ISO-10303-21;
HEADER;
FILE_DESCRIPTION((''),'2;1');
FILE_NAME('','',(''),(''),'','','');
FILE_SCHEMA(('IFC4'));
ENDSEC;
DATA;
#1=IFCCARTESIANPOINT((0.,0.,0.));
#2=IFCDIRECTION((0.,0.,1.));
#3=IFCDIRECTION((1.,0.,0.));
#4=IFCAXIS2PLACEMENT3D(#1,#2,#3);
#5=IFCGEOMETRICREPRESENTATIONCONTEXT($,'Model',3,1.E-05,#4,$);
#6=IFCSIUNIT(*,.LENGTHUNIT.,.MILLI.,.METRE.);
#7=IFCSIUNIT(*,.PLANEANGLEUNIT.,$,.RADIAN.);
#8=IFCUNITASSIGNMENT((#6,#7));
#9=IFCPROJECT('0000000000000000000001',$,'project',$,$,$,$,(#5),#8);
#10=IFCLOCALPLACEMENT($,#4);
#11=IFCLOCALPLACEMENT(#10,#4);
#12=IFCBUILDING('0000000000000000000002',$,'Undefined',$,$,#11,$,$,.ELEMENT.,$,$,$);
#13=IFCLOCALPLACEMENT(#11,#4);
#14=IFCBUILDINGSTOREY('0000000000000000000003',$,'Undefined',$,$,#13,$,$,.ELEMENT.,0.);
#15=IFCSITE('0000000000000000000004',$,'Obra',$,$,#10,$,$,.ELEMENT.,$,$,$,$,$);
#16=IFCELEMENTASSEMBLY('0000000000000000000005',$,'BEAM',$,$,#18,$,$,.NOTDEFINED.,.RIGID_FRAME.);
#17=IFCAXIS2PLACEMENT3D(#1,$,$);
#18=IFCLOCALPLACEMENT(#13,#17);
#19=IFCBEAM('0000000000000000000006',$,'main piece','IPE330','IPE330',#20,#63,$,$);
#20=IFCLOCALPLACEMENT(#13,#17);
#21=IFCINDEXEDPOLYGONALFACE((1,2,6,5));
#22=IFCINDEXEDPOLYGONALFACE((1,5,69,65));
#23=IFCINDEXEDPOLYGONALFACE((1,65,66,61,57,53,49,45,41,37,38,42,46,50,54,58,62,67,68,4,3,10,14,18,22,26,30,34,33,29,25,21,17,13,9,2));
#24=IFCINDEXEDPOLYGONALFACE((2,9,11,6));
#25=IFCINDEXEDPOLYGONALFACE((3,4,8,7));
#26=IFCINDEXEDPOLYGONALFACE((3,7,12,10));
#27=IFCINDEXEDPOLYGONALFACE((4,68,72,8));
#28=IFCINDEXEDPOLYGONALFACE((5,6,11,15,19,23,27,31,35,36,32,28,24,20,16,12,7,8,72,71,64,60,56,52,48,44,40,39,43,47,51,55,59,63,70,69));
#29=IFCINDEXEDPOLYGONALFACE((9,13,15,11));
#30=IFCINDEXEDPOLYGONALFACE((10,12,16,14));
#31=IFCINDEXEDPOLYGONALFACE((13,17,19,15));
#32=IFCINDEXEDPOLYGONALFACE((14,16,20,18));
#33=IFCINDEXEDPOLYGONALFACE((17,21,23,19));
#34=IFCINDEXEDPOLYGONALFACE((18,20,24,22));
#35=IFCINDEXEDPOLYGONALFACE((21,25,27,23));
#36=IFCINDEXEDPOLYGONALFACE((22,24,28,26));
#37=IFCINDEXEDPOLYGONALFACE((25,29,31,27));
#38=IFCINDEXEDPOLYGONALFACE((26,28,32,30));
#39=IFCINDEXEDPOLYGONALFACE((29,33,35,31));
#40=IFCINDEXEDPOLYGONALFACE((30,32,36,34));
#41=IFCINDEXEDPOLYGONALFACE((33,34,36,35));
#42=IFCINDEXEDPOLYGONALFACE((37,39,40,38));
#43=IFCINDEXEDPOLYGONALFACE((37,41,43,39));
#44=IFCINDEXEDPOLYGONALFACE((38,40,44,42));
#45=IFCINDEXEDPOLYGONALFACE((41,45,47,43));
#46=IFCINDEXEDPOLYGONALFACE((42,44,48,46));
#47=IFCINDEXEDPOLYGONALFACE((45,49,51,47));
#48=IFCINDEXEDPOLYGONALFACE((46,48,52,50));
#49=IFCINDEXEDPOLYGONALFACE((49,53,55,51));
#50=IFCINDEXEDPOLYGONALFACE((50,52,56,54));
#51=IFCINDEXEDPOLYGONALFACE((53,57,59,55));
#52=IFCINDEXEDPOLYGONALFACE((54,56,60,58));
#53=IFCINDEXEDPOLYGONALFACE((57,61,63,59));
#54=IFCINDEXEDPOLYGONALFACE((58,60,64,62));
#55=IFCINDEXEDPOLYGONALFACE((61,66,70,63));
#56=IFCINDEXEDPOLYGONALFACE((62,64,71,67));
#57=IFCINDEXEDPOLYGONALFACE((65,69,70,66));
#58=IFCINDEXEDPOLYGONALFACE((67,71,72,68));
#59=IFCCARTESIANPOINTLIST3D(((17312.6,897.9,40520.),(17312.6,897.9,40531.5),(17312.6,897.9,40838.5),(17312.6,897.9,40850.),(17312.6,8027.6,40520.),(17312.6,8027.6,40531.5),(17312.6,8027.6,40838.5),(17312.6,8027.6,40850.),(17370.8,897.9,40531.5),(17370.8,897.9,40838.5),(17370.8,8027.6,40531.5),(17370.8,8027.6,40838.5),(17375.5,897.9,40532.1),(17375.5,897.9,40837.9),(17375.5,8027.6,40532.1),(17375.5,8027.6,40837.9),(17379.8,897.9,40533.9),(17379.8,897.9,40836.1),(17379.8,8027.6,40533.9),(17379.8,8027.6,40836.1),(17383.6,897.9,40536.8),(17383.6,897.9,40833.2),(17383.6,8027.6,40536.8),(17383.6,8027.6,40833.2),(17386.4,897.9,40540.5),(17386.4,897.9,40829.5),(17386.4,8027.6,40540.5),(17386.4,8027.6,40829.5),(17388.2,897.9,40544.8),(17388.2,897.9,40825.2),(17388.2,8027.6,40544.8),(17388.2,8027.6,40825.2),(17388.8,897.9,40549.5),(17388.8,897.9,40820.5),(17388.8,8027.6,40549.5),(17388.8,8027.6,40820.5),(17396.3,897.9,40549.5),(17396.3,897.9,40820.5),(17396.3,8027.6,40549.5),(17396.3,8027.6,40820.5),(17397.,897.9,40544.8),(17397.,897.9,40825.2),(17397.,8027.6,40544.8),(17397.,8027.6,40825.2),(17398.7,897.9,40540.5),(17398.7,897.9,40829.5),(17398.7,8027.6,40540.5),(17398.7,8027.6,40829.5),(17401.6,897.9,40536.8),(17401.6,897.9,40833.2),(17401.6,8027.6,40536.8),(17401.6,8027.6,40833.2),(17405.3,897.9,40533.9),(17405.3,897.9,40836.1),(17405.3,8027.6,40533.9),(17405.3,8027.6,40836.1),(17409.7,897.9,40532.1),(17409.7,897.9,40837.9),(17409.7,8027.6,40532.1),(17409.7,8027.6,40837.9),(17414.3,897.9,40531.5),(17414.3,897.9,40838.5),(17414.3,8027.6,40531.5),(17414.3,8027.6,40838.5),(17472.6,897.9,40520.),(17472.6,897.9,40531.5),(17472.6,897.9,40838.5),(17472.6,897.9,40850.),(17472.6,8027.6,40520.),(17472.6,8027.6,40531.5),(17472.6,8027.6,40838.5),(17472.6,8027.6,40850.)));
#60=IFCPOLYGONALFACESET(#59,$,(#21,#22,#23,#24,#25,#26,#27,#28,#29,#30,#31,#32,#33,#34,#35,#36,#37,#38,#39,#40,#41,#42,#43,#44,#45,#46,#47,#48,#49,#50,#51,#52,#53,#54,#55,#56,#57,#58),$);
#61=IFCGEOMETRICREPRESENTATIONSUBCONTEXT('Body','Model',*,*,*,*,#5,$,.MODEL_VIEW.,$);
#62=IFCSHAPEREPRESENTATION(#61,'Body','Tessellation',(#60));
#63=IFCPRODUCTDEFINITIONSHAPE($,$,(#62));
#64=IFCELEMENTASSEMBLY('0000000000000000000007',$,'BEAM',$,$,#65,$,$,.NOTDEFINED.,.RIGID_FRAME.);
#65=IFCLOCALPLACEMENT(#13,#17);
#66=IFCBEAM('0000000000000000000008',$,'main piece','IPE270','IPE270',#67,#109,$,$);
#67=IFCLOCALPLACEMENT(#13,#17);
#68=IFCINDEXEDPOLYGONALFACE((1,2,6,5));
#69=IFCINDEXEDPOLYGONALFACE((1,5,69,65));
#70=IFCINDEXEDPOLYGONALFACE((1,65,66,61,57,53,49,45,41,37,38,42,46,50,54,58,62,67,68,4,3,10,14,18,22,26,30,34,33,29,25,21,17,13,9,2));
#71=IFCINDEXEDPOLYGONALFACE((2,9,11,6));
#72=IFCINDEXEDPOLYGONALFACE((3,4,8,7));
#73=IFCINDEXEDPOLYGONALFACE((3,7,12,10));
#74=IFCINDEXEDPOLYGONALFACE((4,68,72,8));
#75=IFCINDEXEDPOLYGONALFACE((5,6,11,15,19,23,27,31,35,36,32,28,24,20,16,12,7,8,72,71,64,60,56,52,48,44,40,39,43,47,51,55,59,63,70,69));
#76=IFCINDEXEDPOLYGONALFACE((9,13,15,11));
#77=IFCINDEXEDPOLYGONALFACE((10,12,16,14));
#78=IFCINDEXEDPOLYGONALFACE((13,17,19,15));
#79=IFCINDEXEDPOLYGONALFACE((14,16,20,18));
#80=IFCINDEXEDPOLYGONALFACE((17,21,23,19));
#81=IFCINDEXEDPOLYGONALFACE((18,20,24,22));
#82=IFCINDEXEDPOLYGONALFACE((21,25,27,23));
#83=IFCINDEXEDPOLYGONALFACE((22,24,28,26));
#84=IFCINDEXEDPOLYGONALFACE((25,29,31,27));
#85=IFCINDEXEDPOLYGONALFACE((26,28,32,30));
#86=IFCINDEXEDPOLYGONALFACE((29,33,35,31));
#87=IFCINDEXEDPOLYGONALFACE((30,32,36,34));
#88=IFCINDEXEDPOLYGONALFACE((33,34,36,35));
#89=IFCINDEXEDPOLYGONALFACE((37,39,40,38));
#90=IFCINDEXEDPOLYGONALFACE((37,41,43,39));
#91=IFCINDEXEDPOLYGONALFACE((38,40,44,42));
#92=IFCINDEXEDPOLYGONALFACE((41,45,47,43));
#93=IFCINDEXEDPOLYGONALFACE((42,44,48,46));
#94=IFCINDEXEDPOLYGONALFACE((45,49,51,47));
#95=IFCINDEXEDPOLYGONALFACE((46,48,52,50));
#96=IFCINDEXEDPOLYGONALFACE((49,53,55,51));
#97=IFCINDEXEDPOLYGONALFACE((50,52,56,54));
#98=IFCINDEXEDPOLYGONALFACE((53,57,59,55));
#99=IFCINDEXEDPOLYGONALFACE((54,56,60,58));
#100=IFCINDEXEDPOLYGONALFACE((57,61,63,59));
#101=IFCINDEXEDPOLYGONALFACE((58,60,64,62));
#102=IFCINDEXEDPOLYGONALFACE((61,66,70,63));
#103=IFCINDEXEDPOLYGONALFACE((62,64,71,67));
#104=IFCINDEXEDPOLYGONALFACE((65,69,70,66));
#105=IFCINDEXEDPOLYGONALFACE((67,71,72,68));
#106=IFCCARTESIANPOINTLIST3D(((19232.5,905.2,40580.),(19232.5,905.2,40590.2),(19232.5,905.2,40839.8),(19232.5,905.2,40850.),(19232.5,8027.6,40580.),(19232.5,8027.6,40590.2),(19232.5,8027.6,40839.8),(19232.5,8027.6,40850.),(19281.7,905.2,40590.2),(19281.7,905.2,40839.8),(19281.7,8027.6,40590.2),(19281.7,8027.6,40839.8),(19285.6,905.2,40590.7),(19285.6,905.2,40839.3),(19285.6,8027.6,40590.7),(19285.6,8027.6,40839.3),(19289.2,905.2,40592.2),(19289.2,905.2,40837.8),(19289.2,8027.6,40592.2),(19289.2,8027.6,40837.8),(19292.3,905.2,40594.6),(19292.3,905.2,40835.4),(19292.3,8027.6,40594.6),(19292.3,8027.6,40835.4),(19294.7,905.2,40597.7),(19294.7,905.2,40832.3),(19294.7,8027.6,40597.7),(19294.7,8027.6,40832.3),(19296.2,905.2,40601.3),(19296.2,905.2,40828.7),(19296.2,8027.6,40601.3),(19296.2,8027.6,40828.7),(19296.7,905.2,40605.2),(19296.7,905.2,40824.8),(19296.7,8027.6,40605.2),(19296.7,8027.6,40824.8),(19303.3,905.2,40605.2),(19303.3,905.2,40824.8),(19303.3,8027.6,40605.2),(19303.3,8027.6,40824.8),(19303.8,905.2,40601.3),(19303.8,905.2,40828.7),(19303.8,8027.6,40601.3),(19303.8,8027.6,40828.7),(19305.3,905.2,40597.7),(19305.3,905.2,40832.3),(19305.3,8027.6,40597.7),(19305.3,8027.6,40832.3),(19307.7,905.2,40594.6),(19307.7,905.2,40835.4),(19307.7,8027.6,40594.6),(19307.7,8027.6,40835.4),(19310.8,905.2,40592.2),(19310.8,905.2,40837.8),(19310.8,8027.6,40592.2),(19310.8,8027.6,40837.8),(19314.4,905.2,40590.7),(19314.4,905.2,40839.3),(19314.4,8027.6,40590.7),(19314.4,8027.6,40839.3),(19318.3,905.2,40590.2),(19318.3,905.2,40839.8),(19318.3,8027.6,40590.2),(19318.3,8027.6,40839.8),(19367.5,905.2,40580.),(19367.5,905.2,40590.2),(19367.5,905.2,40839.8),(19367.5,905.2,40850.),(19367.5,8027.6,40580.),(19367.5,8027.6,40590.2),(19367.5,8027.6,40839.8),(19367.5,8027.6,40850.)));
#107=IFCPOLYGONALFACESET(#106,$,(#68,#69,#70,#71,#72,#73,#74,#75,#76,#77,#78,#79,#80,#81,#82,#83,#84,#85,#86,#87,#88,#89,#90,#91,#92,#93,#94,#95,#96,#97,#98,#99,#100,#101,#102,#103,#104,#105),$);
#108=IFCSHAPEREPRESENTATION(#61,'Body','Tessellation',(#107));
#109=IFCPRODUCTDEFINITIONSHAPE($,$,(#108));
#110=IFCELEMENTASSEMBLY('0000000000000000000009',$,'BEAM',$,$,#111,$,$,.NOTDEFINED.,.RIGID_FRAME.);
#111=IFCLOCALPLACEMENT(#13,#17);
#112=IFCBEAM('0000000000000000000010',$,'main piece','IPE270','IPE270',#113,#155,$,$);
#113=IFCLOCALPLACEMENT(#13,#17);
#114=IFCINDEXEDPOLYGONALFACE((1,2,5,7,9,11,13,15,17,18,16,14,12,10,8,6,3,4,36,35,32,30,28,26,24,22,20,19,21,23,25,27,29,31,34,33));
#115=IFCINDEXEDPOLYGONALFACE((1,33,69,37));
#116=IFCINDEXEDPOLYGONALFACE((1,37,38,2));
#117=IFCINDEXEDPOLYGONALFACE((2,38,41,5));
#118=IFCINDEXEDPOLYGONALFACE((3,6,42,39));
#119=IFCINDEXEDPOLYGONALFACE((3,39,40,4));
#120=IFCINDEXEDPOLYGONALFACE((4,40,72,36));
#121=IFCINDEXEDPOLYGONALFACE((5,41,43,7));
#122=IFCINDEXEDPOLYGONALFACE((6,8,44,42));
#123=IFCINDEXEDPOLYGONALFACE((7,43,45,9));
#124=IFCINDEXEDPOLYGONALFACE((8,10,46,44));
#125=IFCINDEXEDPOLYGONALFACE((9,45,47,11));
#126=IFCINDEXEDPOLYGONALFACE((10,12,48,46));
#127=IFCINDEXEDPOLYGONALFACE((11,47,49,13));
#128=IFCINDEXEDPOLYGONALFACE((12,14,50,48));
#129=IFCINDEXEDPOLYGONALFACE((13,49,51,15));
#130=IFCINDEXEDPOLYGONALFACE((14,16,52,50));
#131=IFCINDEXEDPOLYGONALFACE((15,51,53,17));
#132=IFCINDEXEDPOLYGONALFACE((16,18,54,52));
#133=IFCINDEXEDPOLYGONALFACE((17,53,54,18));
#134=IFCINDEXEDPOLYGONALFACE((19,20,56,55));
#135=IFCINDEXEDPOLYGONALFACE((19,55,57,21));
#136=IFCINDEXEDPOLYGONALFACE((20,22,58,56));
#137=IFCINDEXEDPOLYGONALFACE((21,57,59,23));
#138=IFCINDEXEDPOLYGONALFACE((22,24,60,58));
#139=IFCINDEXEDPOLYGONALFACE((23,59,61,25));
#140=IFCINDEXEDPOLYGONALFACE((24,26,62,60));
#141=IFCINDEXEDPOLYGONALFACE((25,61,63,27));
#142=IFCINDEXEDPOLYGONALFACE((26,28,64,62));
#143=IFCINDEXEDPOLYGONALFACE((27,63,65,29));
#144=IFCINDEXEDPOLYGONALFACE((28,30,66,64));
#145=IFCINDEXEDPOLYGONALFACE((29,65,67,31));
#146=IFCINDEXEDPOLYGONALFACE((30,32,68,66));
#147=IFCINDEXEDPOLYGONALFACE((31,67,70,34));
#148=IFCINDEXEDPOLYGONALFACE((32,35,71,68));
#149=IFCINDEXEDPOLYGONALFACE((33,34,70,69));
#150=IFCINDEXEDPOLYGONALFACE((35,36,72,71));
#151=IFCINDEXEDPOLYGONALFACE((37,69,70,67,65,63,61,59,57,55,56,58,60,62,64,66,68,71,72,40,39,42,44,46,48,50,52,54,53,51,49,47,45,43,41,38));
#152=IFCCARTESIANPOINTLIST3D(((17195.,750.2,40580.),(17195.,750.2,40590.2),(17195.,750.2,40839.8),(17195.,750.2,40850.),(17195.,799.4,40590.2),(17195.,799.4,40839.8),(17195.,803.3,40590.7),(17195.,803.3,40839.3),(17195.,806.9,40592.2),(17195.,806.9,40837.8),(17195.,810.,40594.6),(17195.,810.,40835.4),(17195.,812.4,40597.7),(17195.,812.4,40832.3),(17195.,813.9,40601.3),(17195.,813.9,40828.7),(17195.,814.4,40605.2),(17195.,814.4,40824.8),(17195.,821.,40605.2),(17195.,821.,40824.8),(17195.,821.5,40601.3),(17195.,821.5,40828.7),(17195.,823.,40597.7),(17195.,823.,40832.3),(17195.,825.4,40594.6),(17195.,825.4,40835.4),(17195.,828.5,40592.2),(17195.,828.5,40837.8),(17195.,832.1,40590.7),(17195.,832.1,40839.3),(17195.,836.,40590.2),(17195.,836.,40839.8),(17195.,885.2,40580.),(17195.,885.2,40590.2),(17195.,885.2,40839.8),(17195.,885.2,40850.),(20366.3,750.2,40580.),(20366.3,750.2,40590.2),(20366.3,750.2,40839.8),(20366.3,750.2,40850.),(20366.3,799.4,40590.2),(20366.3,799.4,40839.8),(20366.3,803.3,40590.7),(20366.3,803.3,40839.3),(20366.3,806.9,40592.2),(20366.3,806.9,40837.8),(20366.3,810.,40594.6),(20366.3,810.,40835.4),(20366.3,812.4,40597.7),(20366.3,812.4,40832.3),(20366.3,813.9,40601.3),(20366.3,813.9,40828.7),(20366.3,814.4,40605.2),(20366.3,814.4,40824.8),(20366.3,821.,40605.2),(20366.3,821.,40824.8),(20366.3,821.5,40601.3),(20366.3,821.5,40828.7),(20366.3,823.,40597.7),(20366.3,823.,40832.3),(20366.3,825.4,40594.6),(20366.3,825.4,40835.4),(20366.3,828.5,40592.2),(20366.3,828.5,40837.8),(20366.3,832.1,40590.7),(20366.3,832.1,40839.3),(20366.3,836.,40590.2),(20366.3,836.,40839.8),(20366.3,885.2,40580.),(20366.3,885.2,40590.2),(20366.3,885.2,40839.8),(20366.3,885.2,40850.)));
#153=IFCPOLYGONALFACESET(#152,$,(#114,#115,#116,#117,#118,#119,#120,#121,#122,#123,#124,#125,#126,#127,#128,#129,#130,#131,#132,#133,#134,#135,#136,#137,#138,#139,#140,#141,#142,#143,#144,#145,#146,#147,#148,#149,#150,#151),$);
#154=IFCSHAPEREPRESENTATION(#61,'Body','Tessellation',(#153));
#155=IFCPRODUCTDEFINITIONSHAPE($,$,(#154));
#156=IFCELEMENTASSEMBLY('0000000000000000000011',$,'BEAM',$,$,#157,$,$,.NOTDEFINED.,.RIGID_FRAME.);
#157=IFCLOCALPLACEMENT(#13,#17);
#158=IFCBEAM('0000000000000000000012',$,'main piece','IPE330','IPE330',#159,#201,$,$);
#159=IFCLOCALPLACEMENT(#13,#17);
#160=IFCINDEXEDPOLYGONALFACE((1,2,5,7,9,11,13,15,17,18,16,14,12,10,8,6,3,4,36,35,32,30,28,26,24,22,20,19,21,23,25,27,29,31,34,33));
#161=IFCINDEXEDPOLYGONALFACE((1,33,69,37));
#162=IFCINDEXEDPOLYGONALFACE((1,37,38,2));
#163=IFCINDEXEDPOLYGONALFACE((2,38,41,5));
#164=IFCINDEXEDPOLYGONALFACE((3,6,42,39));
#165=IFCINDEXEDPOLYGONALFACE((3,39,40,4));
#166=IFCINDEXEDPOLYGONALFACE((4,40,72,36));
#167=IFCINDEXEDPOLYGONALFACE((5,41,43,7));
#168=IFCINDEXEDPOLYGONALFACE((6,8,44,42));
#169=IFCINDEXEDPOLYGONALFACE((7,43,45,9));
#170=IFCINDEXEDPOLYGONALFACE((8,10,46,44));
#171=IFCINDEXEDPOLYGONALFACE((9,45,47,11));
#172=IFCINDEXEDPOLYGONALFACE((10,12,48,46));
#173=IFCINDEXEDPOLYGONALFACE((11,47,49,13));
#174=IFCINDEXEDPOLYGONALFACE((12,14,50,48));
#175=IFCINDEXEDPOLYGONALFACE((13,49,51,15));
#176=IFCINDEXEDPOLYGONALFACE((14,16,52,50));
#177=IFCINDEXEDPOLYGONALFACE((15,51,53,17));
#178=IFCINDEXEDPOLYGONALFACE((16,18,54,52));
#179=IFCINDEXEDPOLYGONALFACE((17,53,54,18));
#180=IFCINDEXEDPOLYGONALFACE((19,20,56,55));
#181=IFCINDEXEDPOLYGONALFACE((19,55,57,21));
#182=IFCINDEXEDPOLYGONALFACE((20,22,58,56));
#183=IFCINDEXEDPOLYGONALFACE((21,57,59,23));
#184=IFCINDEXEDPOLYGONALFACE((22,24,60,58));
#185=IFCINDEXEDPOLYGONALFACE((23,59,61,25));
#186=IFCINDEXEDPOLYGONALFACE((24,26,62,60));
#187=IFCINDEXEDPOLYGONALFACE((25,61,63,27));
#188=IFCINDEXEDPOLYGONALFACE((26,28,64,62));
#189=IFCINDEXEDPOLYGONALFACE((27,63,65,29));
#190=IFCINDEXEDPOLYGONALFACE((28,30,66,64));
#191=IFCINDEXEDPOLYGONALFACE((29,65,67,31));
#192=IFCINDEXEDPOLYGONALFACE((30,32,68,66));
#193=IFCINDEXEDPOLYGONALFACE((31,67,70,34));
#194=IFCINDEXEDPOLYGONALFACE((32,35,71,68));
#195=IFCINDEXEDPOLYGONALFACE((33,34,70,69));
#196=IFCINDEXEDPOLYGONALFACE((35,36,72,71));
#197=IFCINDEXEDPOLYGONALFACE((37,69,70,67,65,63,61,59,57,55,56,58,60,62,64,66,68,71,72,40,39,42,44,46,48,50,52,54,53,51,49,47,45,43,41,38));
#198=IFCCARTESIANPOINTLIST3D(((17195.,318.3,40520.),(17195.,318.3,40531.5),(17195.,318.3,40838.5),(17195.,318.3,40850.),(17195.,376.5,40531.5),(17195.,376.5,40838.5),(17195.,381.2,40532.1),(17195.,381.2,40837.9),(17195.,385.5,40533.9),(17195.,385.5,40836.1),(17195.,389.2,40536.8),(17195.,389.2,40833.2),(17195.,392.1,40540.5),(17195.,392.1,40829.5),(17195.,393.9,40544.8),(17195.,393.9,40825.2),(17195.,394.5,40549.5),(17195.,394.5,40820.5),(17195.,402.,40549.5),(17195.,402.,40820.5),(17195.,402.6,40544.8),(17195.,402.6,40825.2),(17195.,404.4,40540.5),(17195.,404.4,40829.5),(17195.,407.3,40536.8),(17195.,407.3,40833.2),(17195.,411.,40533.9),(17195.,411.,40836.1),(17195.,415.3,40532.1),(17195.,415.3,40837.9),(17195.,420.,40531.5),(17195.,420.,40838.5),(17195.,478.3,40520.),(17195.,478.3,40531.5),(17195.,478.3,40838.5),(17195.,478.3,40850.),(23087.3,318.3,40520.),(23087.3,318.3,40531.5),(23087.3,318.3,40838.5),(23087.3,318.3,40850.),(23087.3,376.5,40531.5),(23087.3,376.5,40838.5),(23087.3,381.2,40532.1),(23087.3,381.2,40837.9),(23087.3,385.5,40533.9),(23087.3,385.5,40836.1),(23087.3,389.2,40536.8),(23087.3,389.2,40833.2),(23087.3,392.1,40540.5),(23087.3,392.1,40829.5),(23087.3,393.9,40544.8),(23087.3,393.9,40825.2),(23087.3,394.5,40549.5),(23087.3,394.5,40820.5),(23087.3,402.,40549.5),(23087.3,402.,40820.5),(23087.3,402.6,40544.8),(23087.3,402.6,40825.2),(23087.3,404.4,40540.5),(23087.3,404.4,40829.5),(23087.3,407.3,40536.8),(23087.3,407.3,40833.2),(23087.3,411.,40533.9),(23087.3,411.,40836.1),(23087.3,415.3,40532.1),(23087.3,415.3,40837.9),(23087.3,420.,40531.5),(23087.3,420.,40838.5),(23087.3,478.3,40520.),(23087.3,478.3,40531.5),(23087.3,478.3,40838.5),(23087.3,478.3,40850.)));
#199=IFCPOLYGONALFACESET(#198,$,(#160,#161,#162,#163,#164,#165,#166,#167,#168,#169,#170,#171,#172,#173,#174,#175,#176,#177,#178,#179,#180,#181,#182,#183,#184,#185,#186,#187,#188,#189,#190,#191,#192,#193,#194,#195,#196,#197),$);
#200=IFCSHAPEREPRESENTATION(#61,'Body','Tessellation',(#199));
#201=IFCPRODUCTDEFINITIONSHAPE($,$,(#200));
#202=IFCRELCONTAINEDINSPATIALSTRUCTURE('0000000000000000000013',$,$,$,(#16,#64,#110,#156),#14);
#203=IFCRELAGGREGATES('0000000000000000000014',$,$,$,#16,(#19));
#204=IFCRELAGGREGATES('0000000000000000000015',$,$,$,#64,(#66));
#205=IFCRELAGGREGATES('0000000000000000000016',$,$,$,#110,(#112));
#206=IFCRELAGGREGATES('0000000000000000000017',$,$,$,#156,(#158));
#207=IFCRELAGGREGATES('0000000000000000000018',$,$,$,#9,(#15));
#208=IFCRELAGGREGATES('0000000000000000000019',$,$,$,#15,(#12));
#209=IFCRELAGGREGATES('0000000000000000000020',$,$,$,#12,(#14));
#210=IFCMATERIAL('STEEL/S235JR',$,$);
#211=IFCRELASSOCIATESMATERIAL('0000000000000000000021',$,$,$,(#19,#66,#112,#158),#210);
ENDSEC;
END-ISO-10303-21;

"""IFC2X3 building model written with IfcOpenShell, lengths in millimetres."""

from ifc_helpers import new_model, si_unit, frame, origin_with_axes, origin_2d_with_axis, place, context, subcontext, project, spatial, i_section, extrude, material, element, aggregate, save


model = new_model("IFC2X3")

# Units and contexts
model_context = context("Model", 3, precision=1e-05, world=origin_with_axes())
body_context = subcontext(model_context, "Body", "Model", "MODEL_VIEW")
ifc_project = project(units=[si_unit("LENGTHUNIT", "METRE", prefix="MILLI"), si_unit("PLANEANGLEUNIT", "RADIAN")], contexts=[model_context])

# Site, building, storey
site_placement = place(None, origin_with_axes())
site = spatial("IfcSite", under=ifc_project, at=site_placement, Name="Obra", CompositionType="ELEMENT")
building_placement = place(site_placement, origin_with_axes())
building = spatial("IfcBuilding", under=site, at=building_placement, Name="Undefined", CompositionType="ELEMENT")
storey_placement = place(building_placement, origin_with_axes())
storey = spatial("IfcBuildingStorey", under=building, at=storey_placement, Name="Undefined", CompositionType="ELEMENT", Elevation=0.0)

# Shared definitions
ifc_material_1 = material(Name="STEEL/S235JR")

# Element assemblies, beams
assembly_1_placement = place(storey_placement, origin_with_axes())
assembly_1 = element("IfcElementAssembly", 1, at=assembly_1_placement, inside=storey, Name="BEAM", AssemblyPlace="NOTDEFINED", PredefinedType="RIGID_FRAME")
beam_1_placement = place(assembly_1_placement, frame((17392.6, 897.9, 40685.0), z_axis=(0.0, 0.0, 1.0), x_axis=(0.0, 1.0, 0.0)))
beam_1 = element("IfcBeam", 2, at=beam_1_placement, material=ifc_material_1, Name="main piece", Description="IPE330", ObjectType="IPE330", context=body_context, shape_type="SweptSolid", body=[
    extrude(i_section(OverallWidth=160.0, OverallDepth=330.0, WebThickness=7.5, FlangeThickness=11.5, FilletRadius=18.0, at=origin_2d_with_axis()), frame((7129.7, 0.0, 0.0), z_axis=(-1.0, 0.0, 0.0), x_axis=(0.0, -1.0, 0.0)), (0.0, 0.0, 1.0), 7129.7),
])
aggregate(assembly_1, [beam_1])
assembly_2_placement = place(storey_placement, origin_with_axes())
assembly_2 = element("IfcElementAssembly", 3, at=assembly_2_placement, inside=storey, Name="BEAM", AssemblyPlace="NOTDEFINED", PredefinedType="RIGID_FRAME")
beam_2_placement = place(assembly_2_placement, frame((19300.0, 905.2, 40715.0), z_axis=(0.0, 0.0, 1.0), x_axis=(0.0, 1.0, 0.0)))
beam_2 = element("IfcBeam", 4, at=beam_2_placement, material=ifc_material_1, Name="main piece", Description="IPE270", ObjectType="IPE270", context=body_context, shape_type="SweptSolid", body=[
    extrude(i_section(OverallWidth=135.0, OverallDepth=270.0, WebThickness=6.6, FlangeThickness=10.2, FilletRadius=15.0, at=origin_2d_with_axis()), frame((7122.4, 0.0, 0.0), z_axis=(-1.0, 0.0, 0.0), x_axis=(0.0, -1.0, 0.0)), (0.0, 0.0, 1.0), 7122.4),
])
aggregate(assembly_2, [beam_2])
assembly_3_placement = place(storey_placement, origin_with_axes())
assembly_3 = element("IfcElementAssembly", 5, at=assembly_3_placement, inside=storey, Name="BEAM", AssemblyPlace="NOTDEFINED", PredefinedType="RIGID_FRAME")
beam_3_placement = place(assembly_3_placement, frame((17195.0, 817.7, 40715.0), z_axis=(0.0, 0.0, 1.0), x_axis=(1.0, 0.0, 0.0)))
beam_3 = element("IfcBeam", 6, at=beam_3_placement, material=ifc_material_1, Name="main piece", Description="IPE270", ObjectType="IPE270", context=body_context, shape_type="SweptSolid", body=[
    extrude(i_section(OverallWidth=135.0, OverallDepth=270.0, WebThickness=6.6, FlangeThickness=10.2, FilletRadius=15.0, at=origin_2d_with_axis()), frame((3171.3, 0.0, 0.0), z_axis=(-1.0, 0.0, 0.0), x_axis=(0.0, -1.0, 0.0)), (0.0, 0.0, 1.0), 3171.3),
])
aggregate(assembly_3, [beam_3])
assembly_4_placement = place(storey_placement, origin_with_axes())
assembly_4 = element("IfcElementAssembly", 7, at=assembly_4_placement, inside=storey, Name="BEAM", AssemblyPlace="NOTDEFINED", PredefinedType="RIGID_FRAME")
beam_4_placement = place(assembly_4_placement, frame((17195.0, 398.3, 40685.0), z_axis=(0.0, 0.0, 1.0), x_axis=(1.0, 0.0, 0.0)))
beam_4 = element("IfcBeam", 8, at=beam_4_placement, material=ifc_material_1, Name="main piece", Description="IPE330", ObjectType="IPE330", context=body_context, shape_type="SweptSolid", body=[
    extrude(i_section(OverallWidth=160.0, OverallDepth=330.0, WebThickness=7.5, FlangeThickness=11.5, FilletRadius=18.0, at=origin_2d_with_axis()), frame((5892.3, 0.0, 0.0), z_axis=(-1.0, 0.0, 0.0), x_axis=(0.0, -1.0, 0.0)), (0.0, 0.0, 1.0), 5892.3),
])
aggregate(assembly_4, [beam_4])

save(model, "model.ifc")
